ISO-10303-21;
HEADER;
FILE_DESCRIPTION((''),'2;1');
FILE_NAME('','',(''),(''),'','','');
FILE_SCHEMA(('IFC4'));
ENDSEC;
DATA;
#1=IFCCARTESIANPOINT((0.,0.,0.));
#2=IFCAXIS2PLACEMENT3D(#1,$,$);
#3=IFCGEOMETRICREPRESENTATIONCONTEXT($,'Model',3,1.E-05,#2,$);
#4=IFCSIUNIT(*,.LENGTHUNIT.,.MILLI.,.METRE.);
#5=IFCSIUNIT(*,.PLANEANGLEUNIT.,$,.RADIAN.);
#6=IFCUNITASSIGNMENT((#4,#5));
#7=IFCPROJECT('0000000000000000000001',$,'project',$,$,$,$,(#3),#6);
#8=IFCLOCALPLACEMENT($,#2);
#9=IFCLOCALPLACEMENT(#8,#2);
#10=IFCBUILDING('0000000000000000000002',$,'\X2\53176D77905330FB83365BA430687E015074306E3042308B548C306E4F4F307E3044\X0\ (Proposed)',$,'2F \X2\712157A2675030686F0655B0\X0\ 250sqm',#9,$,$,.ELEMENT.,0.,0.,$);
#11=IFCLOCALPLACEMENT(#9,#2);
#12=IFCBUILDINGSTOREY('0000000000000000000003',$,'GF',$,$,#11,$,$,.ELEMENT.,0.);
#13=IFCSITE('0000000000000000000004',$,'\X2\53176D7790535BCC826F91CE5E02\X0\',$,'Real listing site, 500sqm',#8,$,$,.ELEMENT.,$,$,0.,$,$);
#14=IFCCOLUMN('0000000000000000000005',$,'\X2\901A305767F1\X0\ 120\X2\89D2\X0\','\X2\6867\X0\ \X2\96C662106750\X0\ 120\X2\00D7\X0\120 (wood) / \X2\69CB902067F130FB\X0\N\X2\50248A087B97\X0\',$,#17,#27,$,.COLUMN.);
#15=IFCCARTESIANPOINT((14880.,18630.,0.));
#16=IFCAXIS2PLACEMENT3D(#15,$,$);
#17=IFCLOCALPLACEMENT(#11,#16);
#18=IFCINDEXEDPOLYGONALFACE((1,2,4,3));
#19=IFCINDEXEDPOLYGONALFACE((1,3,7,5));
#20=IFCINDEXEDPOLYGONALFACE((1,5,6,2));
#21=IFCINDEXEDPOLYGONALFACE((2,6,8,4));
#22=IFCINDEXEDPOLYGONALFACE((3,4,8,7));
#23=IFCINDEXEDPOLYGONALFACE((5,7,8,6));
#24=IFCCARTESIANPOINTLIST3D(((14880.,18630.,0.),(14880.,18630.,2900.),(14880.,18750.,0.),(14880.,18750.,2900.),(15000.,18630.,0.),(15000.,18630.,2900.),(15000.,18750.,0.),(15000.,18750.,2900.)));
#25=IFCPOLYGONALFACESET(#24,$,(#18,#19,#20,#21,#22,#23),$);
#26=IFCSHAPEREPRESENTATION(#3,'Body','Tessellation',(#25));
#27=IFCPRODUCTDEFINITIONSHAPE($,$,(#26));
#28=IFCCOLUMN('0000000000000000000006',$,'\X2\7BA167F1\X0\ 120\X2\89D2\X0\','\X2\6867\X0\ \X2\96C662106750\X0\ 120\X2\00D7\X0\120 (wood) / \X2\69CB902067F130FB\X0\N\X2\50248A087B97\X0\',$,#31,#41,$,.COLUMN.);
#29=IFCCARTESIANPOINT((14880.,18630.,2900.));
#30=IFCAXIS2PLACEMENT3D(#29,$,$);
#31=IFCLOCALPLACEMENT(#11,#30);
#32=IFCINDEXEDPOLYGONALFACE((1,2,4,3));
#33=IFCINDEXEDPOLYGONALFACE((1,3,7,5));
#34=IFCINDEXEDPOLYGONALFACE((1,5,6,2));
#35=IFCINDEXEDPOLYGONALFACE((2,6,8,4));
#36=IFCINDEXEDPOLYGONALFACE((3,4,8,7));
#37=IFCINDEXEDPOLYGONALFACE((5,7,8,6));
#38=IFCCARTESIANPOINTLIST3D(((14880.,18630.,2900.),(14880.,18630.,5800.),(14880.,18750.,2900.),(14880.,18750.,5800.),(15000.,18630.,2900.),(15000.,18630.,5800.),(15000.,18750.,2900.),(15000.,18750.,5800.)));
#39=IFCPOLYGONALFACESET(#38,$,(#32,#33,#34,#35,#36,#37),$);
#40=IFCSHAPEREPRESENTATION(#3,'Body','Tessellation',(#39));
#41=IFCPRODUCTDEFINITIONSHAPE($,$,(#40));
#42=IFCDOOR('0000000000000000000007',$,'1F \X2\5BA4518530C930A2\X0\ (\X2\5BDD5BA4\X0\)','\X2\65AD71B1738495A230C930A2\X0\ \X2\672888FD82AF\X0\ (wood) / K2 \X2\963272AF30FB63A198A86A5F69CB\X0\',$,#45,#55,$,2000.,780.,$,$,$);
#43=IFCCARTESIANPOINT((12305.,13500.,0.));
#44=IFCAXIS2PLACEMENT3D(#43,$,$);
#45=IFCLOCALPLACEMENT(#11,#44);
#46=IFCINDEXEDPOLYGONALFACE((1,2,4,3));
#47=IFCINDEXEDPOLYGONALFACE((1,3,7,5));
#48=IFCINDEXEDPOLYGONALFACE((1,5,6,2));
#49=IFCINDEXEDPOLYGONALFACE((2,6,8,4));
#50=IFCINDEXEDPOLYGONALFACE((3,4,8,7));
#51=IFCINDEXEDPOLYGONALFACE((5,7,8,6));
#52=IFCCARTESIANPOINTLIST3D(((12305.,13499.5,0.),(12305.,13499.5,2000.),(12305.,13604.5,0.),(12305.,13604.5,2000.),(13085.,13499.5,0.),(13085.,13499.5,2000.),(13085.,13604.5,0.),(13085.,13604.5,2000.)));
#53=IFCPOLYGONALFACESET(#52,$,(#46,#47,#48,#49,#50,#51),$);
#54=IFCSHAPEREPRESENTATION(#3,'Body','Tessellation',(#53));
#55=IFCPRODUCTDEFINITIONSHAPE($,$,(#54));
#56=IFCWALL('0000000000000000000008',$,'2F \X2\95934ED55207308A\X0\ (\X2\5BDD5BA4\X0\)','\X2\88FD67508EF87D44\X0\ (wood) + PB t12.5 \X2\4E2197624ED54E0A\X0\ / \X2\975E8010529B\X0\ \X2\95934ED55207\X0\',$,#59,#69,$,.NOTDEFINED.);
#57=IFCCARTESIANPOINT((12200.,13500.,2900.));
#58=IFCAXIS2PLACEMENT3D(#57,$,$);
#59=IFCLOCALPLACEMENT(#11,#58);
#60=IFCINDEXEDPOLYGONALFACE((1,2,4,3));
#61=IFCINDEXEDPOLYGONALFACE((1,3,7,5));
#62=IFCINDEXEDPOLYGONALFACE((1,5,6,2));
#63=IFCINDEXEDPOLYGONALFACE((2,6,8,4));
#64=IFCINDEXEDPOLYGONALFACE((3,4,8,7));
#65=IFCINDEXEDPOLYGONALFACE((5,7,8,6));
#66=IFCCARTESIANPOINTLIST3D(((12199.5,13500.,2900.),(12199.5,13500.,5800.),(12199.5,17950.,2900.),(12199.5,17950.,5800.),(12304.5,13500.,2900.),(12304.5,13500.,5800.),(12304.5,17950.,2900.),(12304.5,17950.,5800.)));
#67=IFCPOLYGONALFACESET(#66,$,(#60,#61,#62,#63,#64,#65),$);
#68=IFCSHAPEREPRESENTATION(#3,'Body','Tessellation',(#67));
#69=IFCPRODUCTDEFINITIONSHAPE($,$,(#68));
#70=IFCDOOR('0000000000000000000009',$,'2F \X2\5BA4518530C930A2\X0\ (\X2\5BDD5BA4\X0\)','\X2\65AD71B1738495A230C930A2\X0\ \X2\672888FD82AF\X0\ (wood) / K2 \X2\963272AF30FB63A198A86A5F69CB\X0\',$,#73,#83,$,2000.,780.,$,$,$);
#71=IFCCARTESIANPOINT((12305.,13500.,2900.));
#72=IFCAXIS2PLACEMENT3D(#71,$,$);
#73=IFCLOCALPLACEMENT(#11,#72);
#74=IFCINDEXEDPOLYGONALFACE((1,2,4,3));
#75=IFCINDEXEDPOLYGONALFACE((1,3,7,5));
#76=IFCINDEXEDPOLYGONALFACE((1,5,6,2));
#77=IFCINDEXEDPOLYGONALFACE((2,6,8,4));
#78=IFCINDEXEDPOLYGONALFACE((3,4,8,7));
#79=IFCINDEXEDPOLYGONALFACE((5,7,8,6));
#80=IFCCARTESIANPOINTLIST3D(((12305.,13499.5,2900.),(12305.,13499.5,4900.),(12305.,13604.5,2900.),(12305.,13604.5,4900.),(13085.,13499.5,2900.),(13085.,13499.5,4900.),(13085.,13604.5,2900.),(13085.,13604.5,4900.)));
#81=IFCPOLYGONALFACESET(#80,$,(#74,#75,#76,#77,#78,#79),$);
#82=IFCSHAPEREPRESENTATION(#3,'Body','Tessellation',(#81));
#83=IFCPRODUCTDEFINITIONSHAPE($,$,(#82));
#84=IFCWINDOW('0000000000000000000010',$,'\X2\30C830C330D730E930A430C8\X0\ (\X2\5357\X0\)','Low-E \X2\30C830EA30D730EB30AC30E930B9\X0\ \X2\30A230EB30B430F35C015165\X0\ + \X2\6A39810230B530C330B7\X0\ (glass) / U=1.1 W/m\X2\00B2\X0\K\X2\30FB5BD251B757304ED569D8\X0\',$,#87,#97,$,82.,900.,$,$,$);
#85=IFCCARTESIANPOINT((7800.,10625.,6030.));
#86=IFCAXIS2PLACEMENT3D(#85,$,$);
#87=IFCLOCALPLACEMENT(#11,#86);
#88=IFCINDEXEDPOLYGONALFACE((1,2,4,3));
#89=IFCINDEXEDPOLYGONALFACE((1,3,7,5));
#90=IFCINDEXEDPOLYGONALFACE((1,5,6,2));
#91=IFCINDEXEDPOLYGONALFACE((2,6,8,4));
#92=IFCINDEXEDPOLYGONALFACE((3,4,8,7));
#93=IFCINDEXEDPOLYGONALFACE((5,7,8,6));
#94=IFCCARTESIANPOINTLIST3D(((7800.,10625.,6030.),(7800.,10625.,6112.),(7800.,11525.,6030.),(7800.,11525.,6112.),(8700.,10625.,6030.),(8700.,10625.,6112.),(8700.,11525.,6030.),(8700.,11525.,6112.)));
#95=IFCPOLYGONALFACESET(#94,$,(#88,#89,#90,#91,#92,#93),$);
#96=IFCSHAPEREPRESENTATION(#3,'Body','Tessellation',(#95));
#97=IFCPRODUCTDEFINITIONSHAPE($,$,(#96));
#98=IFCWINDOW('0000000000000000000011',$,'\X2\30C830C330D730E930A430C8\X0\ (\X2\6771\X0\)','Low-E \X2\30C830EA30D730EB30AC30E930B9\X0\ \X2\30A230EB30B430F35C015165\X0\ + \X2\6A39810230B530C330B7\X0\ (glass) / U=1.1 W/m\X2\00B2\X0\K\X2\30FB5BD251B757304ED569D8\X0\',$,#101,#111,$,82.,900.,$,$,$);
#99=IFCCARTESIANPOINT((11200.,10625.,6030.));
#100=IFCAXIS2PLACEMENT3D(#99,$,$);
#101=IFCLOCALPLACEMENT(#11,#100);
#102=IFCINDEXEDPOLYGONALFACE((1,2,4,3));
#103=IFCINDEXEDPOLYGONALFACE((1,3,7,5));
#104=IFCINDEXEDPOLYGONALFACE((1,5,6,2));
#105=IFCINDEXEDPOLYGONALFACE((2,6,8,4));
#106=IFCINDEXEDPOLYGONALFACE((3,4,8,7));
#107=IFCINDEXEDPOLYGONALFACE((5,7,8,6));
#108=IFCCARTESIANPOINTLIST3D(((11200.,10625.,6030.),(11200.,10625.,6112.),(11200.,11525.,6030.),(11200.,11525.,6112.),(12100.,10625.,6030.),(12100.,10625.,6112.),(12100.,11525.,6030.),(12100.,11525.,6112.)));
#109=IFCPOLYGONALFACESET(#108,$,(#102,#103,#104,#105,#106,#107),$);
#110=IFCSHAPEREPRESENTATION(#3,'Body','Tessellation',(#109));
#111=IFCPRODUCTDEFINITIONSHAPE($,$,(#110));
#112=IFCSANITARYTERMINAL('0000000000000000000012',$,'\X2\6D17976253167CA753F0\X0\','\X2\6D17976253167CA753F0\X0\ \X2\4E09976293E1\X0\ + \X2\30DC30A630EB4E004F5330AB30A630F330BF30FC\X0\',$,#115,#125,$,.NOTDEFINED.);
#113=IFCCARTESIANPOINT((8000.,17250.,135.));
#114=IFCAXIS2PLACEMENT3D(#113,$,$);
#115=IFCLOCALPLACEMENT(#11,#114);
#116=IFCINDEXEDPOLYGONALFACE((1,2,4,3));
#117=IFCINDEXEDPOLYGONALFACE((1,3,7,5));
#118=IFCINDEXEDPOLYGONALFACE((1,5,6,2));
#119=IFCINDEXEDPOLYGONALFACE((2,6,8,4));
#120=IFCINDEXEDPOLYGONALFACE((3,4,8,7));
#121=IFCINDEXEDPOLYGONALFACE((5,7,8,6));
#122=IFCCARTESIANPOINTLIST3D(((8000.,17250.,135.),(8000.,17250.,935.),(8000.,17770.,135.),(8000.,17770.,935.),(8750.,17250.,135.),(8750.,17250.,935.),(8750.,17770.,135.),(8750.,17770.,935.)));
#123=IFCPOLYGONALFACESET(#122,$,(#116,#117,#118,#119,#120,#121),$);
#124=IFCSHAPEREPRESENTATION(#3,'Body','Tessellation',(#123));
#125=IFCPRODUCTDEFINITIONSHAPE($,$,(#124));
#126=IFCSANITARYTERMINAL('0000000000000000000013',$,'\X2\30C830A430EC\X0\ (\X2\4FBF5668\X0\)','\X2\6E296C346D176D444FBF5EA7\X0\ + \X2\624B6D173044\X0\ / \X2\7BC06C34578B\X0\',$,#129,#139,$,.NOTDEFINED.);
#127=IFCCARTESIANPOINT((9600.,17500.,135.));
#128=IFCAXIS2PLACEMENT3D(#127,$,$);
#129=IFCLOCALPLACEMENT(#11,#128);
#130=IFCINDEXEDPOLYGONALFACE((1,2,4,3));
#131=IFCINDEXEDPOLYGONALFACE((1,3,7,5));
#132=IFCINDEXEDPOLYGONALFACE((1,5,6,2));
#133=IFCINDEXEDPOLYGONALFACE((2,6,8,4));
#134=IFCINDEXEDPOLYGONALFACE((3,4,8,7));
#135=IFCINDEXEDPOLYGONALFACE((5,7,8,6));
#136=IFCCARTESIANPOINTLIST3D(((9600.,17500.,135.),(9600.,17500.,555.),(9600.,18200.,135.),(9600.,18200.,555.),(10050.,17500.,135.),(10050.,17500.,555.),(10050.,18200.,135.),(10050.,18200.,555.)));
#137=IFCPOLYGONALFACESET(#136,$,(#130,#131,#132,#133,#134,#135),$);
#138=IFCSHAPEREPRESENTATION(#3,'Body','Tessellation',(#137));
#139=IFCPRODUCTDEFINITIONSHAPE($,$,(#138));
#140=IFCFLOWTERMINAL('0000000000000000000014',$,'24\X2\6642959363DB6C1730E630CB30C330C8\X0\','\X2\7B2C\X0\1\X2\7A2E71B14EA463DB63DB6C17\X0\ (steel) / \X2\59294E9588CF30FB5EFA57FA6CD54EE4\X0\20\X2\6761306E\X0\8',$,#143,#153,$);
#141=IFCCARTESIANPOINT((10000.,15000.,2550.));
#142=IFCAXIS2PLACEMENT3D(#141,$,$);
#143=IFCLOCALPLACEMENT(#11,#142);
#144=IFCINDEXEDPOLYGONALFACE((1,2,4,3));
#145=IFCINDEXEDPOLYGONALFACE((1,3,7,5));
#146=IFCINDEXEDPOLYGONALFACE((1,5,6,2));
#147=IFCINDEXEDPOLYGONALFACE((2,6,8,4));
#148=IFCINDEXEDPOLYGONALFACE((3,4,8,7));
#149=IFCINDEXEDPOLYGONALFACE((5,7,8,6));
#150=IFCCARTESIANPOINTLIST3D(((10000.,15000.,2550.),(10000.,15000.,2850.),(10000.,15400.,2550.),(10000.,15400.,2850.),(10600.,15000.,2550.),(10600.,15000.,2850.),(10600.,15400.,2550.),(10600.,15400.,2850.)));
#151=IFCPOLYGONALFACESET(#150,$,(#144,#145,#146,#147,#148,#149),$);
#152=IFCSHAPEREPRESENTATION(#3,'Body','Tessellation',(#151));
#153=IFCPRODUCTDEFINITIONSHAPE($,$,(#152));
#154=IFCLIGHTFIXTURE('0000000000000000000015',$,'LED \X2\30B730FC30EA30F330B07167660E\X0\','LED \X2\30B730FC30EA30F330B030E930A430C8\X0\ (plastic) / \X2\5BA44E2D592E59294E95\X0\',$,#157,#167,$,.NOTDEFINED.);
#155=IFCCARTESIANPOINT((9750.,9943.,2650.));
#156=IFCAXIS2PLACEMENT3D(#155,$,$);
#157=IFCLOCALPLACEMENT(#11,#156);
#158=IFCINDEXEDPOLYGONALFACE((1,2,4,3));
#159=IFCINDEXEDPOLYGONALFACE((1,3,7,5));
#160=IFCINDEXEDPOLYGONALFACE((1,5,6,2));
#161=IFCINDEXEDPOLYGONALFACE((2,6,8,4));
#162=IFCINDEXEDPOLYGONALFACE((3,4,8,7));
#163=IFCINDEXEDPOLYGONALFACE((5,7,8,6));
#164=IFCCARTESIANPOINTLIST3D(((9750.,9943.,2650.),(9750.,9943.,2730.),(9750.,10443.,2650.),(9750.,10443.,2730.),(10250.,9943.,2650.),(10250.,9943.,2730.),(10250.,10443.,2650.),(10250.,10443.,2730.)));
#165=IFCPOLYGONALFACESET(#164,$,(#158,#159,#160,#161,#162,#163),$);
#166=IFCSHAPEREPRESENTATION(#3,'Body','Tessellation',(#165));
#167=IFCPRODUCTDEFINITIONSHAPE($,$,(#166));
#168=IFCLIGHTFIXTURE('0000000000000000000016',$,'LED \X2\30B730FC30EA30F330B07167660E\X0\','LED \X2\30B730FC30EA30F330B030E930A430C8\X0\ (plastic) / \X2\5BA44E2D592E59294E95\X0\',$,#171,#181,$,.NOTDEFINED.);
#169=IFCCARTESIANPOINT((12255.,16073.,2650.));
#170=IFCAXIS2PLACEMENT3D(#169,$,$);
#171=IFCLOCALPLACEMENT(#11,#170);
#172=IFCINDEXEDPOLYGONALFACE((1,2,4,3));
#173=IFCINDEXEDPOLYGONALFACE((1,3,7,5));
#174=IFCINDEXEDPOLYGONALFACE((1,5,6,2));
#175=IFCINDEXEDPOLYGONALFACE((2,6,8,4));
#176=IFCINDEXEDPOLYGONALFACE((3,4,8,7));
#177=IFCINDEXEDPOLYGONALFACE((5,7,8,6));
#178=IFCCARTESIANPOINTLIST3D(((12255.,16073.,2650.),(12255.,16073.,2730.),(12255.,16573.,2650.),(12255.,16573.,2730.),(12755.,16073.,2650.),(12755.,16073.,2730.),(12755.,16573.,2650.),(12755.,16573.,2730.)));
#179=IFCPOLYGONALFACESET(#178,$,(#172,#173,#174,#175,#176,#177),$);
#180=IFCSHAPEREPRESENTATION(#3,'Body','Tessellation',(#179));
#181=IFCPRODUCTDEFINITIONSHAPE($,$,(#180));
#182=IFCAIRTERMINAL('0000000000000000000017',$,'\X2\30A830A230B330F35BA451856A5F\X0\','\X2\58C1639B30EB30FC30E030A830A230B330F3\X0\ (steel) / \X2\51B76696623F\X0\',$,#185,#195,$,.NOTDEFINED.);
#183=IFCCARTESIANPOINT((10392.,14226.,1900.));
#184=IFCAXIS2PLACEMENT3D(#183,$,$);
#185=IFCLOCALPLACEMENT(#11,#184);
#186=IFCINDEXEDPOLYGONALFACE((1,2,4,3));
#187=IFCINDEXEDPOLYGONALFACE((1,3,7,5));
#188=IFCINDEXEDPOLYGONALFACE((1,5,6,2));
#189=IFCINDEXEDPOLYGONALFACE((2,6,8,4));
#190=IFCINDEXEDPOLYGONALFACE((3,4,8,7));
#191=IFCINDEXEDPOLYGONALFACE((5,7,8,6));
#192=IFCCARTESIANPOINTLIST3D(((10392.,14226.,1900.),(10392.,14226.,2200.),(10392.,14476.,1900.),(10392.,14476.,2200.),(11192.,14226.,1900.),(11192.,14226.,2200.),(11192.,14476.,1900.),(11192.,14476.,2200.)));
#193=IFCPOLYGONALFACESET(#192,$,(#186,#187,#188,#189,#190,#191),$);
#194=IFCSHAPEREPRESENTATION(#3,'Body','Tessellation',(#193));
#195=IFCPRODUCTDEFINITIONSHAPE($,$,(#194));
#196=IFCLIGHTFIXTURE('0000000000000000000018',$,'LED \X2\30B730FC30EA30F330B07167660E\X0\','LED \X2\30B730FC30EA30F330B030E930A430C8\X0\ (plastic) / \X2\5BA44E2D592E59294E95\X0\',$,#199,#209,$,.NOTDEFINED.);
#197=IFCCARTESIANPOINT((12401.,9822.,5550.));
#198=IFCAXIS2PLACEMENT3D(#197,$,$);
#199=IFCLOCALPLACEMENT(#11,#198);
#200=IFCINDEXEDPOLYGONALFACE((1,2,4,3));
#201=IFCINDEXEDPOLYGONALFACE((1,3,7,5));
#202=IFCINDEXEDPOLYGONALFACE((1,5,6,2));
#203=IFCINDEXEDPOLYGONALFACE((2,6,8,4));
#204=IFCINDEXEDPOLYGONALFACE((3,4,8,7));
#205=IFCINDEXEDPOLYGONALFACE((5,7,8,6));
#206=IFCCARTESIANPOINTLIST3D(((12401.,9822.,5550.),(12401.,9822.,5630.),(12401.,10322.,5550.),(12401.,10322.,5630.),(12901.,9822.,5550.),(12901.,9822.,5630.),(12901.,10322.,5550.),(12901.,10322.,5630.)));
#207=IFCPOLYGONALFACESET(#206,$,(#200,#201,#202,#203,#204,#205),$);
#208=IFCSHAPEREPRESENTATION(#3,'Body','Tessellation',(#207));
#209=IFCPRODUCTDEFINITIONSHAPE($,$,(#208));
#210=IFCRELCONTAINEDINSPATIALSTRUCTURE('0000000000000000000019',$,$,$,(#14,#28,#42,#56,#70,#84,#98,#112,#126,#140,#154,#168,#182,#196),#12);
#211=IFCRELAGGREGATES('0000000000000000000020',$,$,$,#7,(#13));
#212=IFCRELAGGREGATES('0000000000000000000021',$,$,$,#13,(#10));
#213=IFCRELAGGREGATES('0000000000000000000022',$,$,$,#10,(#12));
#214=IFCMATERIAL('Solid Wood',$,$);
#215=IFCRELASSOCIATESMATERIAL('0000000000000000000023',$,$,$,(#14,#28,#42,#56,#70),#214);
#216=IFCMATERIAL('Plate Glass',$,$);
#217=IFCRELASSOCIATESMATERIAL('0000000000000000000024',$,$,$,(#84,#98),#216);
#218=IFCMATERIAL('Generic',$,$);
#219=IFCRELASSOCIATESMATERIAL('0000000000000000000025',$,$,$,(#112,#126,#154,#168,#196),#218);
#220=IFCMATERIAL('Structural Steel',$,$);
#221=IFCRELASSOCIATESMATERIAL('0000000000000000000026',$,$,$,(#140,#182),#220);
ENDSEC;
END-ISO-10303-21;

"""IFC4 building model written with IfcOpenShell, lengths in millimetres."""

from ifc_helpers import new_model, si_unit, frame, frame_2d, origin, place, context, project, spatial, rectangle, extrude, material, element, save


model = new_model("IFC4")

# Units and contexts
model_context = context("Model", 3, precision=1e-05, world=origin())
ifc_project = project(units=[si_unit("LENGTHUNIT", "METRE", prefix="MILLI"), si_unit("PLANEANGLEUNIT", "RADIAN")], contexts=[model_context])

# Site, building, storey
site_placement = place(None, origin())
site = spatial("IfcSite", under=ifc_project, at=site_placement, Name="北海道富良野市", ObjectType="Real listing site, 500sqm", CompositionType="ELEMENT", RefElevation=0.0)
building_placement = place(site_placement, origin())
building = spatial("IfcBuilding", under=site, at=building_placement, Name="北海道・茶室と縁側のある和の住まい (Proposed)", ObjectType="2F 無垢材と漆喰 250sqm", CompositionType="ELEMENT", ElevationOfRefHeight=0.0, ElevationOfTerrain=0.0)
storey_placement = place(building_placement, origin())
storey = spatial("IfcBuildingStorey", under=building, at=storey_placement, Name="GF", CompositionType="ELEMENT", Elevation=0.0)

# Columns
ifc_material_1 = material(Name="Solid Wood")
column_1_placement = place(storey_placement, frame((14880.0, 18630.0, 0.0)))
element("IfcColumn", 1, at=column_1_placement, inside=storey, material=ifc_material_1, Name="通し柱 120角", Description="桧 集成材 120×120 (wood) / 構造柱・N値計算", PredefinedType="COLUMN", context=model_context, shape_type="SweptSolid", body=[
    extrude(rectangle(XDim=120.0, YDim=120.0, at=frame_2d((60.0, 60.0))), frame((14880.0, 18630.0, 0.0)), (0.0, 0.0, 1.0), 2900.0),
])
column_2_placement = place(storey_placement, frame((14880.0, 18630.0, 2900.0)))
element("IfcColumn", 2, at=column_2_placement, inside=storey, material=ifc_material_1, Name="管柱 120角", Description="桧 集成材 120×120 (wood) / 構造柱・N値計算", PredefinedType="COLUMN", context=model_context, shape_type="SweptSolid", body=[
    extrude(rectangle(XDim=120.0, YDim=120.0, at=frame_2d((60.0, 60.0))), frame((14880.0, 18630.0, 2900.0)), (0.0, 0.0, 1.0), 2900.0),
])

# Door
door_1_placement = place(storey_placement, frame((12305.0, 13500.0, 0.0)))
element("IfcDoor", 3, at=door_1_placement, inside=storey, material=ifc_material_1, Name="1F 室内ドア (寝室)", Description="断熱玄関ドア 木製芯 (wood) / K2 防犯・採風機構", OverallHeight=2000.0, OverallWidth=780.0, context=model_context, shape_type="SweptSolid", body=[
    extrude(rectangle(XDim=780.0, YDim=105.0, at=frame_2d((390.0, 52.0))), frame((12305.0, 13500.0, 0.0)), (0.0, 0.0, 1.0), 2000.0),
])

# Wall
wall_1_placement = place(storey_placement, frame((12200.0, 13500.0, 2900.0)))
element("IfcWall", 4, at=wall_1_placement, inside=storey, material=ifc_material_1, Name="2F 間仕切り (寝室)", Description="製材軸組 (wood) + PB t12.5 両面仕上 / 非耐力 間仕切", PredefinedType="NOTDEFINED", context=model_context, shape_type="SweptSolid", body=[
    extrude(rectangle(XDim=105.0, YDim=4450.0, at=frame_2d((52.0, 2225.0))), frame((12200.0, 13500.0, 2900.0)), (0.0, 0.0, 1.0), 2900.0),
])

# Door
door_2_placement = place(storey_placement, frame((12305.0, 13500.0, 2900.0)))
element("IfcDoor", 5, at=door_2_placement, inside=storey, material=ifc_material_1, Name="2F 室内ドア (寝室)", Description="断熱玄関ドア 木製芯 (wood) / K2 防犯・採風機構", OverallHeight=2000.0, OverallWidth=780.0, context=model_context, shape_type="SweptSolid", body=[
    extrude(rectangle(XDim=780.0, YDim=105.0, at=frame_2d((390.0, 52.0))), frame((12305.0, 13500.0, 2900.0)), (0.0, 0.0, 1.0), 2000.0),
])

# Windows
ifc_material_2 = material(Name="Plate Glass")
window_1_placement = place(storey_placement, frame((7800.0, 10625.0, 6030.0)))
element("IfcWindow", 6, at=window_1_placement, inside=storey, material=ifc_material_2, Name="トップライト (南)", Description="Low-E トリプルガラス アルゴン封入 + 樹脂サッシ (glass) / U=1.1 W/m²K・寒冷地仕様", OverallHeight=82.0, OverallWidth=900.0, context=model_context, shape_type="SweptSolid", body=[
    extrude(rectangle(XDim=900.0, YDim=900.0, at=frame_2d((450.0, 450.0))), frame((7800.0, 10625.0, 6030.0)), (0.0, 0.0, 1.0), 82.0),
])
window_2_placement = place(storey_placement, frame((11200.0, 10625.0, 6030.0)))
element("IfcWindow", 7, at=window_2_placement, inside=storey, material=ifc_material_2, Name="トップライト (東)", Description="Low-E トリプルガラス アルゴン封入 + 樹脂サッシ (glass) / U=1.1 W/m²K・寒冷地仕様", OverallHeight=82.0, OverallWidth=900.0, context=model_context, shape_type="SweptSolid", body=[
    extrude(rectangle(XDim=900.0, YDim=900.0, at=frame_2d((450.0, 450.0))), frame((11200.0, 10625.0, 6030.0)), (0.0, 0.0, 1.0), 82.0),
])

# Sanitary terminals
ifc_material_3 = material(Name="Generic")
sanitary_terminal_1_placement = place(storey_placement, frame((8000.0, 17250.0, 135.0)))
element("IfcSanitaryTerminal", 8, at=sanitary_terminal_1_placement, inside=storey, material=ifc_material_3, Name="洗面化粧台", Description="洗面化粧台 三面鏡 + ボウル一体カウンター", PredefinedType="NOTDEFINED", context=model_context, shape_type="SweptSolid", body=[
    extrude(rectangle(XDim=750.0, YDim=520.0, at=frame_2d((375.0, 260.0))), frame((8000.0, 17250.0, 135.0)), (0.0, 0.0, 1.0), 800.0),
])
sanitary_terminal_2_placement = place(storey_placement, frame((9600.0, 17500.0, 135.0)))
element("IfcSanitaryTerminal", 9, at=sanitary_terminal_2_placement, inside=storey, material=ifc_material_3, Name="トイレ (便器)", Description="温水洗浄便座 + 手洗い / 節水型", PredefinedType="NOTDEFINED", context=model_context, shape_type="SweptSolid", body=[
    extrude(rectangle(XDim=450.0, YDim=700.0, at=frame_2d((225.0, 350.0))), frame((9600.0, 17500.0, 135.0)), (0.0, 0.0, 1.0), 420.0),
])

# Flow terminal
ifc_material_4 = material(Name="Structural Steel")
flow_terminal_placement = place(storey_placement, frame((10000.0, 15000.0, 2550.0)))
element("IfcFlowTerminal", 10, at=flow_terminal_placement, inside=storey, material=ifc_material_4, Name="24時間換気ユニット", Description="第1種熱交換換気 (steel) / 天井裏・建基法令20条の8", context=model_context, shape_type="SweptSolid", body=[
    extrude(rectangle(XDim=600.0, YDim=400.0, at=frame_2d((300.0, 200.0))), frame((10000.0, 15000.0, 2550.0)), (0.0, 0.0, 1.0), 300.0),
])

# Light fixtures
light_fixture_1_placement = place(storey_placement, frame((9750.0, 9943.0, 2650.0)))
element("IfcLightFixture", 11, at=light_fixture_1_placement, inside=storey, material=ifc_material_3, Name="LED シーリング照明", Description="LED シーリングライト (plastic) / 室中央天井", PredefinedType="NOTDEFINED", context=model_context, shape_type="SweptSolid", body=[
    extrude(rectangle(XDim=500.0, YDim=500.0, at=frame_2d((250.0, 250.0))), frame((9750.0, 9943.0, 2650.0)), (0.0, 0.0, 1.0), 80.0),
])
light_fixture_2_placement = place(storey_placement, frame((12255.0, 16073.0, 2650.0)))
element("IfcLightFixture", 12, at=light_fixture_2_placement, inside=storey, material=ifc_material_3, Name="LED シーリング照明", Description="LED シーリングライト (plastic) / 室中央天井", PredefinedType="NOTDEFINED", context=model_context, shape_type="SweptSolid", body=[
    extrude(rectangle(XDim=500.0, YDim=500.0, at=frame_2d((250.0, 250.0))), frame((12255.0, 16073.0, 2650.0)), (0.0, 0.0, 1.0), 80.0),
])

# Air terminal
air_terminal_placement = place(storey_placement, frame((10392.0, 14226.0, 1900.0)))
element("IfcAirTerminal", 13, at=air_terminal_placement, inside=storey, material=ifc_material_4, Name="エアコン室内機", Description="壁掛ルームエアコン (steel) / 冷暖房", PredefinedType="NOTDEFINED", context=model_context, shape_type="SweptSolid", body=[
    extrude(rectangle(XDim=800.0, YDim=250.0, at=frame_2d((400.0, 125.0))), frame((10392.0, 14226.0, 1900.0)), (0.0, 0.0, 1.0), 300.0),
])

# Light fixture
light_fixture_3_placement = place(storey_placement, frame((12401.0, 9822.0, 5550.0)))
element("IfcLightFixture", 14, at=light_fixture_3_placement, inside=storey, material=ifc_material_3, Name="LED シーリング照明", Description="LED シーリングライト (plastic) / 室中央天井", PredefinedType="NOTDEFINED", context=model_context, shape_type="SweptSolid", body=[
    extrude(rectangle(XDim=500.0, YDim=500.0, at=frame_2d((250.0, 250.0))), frame((12401.0, 9822.0, 5550.0)), (0.0, 0.0, 1.0), 80.0),
])

save(model, "model.ifc")
